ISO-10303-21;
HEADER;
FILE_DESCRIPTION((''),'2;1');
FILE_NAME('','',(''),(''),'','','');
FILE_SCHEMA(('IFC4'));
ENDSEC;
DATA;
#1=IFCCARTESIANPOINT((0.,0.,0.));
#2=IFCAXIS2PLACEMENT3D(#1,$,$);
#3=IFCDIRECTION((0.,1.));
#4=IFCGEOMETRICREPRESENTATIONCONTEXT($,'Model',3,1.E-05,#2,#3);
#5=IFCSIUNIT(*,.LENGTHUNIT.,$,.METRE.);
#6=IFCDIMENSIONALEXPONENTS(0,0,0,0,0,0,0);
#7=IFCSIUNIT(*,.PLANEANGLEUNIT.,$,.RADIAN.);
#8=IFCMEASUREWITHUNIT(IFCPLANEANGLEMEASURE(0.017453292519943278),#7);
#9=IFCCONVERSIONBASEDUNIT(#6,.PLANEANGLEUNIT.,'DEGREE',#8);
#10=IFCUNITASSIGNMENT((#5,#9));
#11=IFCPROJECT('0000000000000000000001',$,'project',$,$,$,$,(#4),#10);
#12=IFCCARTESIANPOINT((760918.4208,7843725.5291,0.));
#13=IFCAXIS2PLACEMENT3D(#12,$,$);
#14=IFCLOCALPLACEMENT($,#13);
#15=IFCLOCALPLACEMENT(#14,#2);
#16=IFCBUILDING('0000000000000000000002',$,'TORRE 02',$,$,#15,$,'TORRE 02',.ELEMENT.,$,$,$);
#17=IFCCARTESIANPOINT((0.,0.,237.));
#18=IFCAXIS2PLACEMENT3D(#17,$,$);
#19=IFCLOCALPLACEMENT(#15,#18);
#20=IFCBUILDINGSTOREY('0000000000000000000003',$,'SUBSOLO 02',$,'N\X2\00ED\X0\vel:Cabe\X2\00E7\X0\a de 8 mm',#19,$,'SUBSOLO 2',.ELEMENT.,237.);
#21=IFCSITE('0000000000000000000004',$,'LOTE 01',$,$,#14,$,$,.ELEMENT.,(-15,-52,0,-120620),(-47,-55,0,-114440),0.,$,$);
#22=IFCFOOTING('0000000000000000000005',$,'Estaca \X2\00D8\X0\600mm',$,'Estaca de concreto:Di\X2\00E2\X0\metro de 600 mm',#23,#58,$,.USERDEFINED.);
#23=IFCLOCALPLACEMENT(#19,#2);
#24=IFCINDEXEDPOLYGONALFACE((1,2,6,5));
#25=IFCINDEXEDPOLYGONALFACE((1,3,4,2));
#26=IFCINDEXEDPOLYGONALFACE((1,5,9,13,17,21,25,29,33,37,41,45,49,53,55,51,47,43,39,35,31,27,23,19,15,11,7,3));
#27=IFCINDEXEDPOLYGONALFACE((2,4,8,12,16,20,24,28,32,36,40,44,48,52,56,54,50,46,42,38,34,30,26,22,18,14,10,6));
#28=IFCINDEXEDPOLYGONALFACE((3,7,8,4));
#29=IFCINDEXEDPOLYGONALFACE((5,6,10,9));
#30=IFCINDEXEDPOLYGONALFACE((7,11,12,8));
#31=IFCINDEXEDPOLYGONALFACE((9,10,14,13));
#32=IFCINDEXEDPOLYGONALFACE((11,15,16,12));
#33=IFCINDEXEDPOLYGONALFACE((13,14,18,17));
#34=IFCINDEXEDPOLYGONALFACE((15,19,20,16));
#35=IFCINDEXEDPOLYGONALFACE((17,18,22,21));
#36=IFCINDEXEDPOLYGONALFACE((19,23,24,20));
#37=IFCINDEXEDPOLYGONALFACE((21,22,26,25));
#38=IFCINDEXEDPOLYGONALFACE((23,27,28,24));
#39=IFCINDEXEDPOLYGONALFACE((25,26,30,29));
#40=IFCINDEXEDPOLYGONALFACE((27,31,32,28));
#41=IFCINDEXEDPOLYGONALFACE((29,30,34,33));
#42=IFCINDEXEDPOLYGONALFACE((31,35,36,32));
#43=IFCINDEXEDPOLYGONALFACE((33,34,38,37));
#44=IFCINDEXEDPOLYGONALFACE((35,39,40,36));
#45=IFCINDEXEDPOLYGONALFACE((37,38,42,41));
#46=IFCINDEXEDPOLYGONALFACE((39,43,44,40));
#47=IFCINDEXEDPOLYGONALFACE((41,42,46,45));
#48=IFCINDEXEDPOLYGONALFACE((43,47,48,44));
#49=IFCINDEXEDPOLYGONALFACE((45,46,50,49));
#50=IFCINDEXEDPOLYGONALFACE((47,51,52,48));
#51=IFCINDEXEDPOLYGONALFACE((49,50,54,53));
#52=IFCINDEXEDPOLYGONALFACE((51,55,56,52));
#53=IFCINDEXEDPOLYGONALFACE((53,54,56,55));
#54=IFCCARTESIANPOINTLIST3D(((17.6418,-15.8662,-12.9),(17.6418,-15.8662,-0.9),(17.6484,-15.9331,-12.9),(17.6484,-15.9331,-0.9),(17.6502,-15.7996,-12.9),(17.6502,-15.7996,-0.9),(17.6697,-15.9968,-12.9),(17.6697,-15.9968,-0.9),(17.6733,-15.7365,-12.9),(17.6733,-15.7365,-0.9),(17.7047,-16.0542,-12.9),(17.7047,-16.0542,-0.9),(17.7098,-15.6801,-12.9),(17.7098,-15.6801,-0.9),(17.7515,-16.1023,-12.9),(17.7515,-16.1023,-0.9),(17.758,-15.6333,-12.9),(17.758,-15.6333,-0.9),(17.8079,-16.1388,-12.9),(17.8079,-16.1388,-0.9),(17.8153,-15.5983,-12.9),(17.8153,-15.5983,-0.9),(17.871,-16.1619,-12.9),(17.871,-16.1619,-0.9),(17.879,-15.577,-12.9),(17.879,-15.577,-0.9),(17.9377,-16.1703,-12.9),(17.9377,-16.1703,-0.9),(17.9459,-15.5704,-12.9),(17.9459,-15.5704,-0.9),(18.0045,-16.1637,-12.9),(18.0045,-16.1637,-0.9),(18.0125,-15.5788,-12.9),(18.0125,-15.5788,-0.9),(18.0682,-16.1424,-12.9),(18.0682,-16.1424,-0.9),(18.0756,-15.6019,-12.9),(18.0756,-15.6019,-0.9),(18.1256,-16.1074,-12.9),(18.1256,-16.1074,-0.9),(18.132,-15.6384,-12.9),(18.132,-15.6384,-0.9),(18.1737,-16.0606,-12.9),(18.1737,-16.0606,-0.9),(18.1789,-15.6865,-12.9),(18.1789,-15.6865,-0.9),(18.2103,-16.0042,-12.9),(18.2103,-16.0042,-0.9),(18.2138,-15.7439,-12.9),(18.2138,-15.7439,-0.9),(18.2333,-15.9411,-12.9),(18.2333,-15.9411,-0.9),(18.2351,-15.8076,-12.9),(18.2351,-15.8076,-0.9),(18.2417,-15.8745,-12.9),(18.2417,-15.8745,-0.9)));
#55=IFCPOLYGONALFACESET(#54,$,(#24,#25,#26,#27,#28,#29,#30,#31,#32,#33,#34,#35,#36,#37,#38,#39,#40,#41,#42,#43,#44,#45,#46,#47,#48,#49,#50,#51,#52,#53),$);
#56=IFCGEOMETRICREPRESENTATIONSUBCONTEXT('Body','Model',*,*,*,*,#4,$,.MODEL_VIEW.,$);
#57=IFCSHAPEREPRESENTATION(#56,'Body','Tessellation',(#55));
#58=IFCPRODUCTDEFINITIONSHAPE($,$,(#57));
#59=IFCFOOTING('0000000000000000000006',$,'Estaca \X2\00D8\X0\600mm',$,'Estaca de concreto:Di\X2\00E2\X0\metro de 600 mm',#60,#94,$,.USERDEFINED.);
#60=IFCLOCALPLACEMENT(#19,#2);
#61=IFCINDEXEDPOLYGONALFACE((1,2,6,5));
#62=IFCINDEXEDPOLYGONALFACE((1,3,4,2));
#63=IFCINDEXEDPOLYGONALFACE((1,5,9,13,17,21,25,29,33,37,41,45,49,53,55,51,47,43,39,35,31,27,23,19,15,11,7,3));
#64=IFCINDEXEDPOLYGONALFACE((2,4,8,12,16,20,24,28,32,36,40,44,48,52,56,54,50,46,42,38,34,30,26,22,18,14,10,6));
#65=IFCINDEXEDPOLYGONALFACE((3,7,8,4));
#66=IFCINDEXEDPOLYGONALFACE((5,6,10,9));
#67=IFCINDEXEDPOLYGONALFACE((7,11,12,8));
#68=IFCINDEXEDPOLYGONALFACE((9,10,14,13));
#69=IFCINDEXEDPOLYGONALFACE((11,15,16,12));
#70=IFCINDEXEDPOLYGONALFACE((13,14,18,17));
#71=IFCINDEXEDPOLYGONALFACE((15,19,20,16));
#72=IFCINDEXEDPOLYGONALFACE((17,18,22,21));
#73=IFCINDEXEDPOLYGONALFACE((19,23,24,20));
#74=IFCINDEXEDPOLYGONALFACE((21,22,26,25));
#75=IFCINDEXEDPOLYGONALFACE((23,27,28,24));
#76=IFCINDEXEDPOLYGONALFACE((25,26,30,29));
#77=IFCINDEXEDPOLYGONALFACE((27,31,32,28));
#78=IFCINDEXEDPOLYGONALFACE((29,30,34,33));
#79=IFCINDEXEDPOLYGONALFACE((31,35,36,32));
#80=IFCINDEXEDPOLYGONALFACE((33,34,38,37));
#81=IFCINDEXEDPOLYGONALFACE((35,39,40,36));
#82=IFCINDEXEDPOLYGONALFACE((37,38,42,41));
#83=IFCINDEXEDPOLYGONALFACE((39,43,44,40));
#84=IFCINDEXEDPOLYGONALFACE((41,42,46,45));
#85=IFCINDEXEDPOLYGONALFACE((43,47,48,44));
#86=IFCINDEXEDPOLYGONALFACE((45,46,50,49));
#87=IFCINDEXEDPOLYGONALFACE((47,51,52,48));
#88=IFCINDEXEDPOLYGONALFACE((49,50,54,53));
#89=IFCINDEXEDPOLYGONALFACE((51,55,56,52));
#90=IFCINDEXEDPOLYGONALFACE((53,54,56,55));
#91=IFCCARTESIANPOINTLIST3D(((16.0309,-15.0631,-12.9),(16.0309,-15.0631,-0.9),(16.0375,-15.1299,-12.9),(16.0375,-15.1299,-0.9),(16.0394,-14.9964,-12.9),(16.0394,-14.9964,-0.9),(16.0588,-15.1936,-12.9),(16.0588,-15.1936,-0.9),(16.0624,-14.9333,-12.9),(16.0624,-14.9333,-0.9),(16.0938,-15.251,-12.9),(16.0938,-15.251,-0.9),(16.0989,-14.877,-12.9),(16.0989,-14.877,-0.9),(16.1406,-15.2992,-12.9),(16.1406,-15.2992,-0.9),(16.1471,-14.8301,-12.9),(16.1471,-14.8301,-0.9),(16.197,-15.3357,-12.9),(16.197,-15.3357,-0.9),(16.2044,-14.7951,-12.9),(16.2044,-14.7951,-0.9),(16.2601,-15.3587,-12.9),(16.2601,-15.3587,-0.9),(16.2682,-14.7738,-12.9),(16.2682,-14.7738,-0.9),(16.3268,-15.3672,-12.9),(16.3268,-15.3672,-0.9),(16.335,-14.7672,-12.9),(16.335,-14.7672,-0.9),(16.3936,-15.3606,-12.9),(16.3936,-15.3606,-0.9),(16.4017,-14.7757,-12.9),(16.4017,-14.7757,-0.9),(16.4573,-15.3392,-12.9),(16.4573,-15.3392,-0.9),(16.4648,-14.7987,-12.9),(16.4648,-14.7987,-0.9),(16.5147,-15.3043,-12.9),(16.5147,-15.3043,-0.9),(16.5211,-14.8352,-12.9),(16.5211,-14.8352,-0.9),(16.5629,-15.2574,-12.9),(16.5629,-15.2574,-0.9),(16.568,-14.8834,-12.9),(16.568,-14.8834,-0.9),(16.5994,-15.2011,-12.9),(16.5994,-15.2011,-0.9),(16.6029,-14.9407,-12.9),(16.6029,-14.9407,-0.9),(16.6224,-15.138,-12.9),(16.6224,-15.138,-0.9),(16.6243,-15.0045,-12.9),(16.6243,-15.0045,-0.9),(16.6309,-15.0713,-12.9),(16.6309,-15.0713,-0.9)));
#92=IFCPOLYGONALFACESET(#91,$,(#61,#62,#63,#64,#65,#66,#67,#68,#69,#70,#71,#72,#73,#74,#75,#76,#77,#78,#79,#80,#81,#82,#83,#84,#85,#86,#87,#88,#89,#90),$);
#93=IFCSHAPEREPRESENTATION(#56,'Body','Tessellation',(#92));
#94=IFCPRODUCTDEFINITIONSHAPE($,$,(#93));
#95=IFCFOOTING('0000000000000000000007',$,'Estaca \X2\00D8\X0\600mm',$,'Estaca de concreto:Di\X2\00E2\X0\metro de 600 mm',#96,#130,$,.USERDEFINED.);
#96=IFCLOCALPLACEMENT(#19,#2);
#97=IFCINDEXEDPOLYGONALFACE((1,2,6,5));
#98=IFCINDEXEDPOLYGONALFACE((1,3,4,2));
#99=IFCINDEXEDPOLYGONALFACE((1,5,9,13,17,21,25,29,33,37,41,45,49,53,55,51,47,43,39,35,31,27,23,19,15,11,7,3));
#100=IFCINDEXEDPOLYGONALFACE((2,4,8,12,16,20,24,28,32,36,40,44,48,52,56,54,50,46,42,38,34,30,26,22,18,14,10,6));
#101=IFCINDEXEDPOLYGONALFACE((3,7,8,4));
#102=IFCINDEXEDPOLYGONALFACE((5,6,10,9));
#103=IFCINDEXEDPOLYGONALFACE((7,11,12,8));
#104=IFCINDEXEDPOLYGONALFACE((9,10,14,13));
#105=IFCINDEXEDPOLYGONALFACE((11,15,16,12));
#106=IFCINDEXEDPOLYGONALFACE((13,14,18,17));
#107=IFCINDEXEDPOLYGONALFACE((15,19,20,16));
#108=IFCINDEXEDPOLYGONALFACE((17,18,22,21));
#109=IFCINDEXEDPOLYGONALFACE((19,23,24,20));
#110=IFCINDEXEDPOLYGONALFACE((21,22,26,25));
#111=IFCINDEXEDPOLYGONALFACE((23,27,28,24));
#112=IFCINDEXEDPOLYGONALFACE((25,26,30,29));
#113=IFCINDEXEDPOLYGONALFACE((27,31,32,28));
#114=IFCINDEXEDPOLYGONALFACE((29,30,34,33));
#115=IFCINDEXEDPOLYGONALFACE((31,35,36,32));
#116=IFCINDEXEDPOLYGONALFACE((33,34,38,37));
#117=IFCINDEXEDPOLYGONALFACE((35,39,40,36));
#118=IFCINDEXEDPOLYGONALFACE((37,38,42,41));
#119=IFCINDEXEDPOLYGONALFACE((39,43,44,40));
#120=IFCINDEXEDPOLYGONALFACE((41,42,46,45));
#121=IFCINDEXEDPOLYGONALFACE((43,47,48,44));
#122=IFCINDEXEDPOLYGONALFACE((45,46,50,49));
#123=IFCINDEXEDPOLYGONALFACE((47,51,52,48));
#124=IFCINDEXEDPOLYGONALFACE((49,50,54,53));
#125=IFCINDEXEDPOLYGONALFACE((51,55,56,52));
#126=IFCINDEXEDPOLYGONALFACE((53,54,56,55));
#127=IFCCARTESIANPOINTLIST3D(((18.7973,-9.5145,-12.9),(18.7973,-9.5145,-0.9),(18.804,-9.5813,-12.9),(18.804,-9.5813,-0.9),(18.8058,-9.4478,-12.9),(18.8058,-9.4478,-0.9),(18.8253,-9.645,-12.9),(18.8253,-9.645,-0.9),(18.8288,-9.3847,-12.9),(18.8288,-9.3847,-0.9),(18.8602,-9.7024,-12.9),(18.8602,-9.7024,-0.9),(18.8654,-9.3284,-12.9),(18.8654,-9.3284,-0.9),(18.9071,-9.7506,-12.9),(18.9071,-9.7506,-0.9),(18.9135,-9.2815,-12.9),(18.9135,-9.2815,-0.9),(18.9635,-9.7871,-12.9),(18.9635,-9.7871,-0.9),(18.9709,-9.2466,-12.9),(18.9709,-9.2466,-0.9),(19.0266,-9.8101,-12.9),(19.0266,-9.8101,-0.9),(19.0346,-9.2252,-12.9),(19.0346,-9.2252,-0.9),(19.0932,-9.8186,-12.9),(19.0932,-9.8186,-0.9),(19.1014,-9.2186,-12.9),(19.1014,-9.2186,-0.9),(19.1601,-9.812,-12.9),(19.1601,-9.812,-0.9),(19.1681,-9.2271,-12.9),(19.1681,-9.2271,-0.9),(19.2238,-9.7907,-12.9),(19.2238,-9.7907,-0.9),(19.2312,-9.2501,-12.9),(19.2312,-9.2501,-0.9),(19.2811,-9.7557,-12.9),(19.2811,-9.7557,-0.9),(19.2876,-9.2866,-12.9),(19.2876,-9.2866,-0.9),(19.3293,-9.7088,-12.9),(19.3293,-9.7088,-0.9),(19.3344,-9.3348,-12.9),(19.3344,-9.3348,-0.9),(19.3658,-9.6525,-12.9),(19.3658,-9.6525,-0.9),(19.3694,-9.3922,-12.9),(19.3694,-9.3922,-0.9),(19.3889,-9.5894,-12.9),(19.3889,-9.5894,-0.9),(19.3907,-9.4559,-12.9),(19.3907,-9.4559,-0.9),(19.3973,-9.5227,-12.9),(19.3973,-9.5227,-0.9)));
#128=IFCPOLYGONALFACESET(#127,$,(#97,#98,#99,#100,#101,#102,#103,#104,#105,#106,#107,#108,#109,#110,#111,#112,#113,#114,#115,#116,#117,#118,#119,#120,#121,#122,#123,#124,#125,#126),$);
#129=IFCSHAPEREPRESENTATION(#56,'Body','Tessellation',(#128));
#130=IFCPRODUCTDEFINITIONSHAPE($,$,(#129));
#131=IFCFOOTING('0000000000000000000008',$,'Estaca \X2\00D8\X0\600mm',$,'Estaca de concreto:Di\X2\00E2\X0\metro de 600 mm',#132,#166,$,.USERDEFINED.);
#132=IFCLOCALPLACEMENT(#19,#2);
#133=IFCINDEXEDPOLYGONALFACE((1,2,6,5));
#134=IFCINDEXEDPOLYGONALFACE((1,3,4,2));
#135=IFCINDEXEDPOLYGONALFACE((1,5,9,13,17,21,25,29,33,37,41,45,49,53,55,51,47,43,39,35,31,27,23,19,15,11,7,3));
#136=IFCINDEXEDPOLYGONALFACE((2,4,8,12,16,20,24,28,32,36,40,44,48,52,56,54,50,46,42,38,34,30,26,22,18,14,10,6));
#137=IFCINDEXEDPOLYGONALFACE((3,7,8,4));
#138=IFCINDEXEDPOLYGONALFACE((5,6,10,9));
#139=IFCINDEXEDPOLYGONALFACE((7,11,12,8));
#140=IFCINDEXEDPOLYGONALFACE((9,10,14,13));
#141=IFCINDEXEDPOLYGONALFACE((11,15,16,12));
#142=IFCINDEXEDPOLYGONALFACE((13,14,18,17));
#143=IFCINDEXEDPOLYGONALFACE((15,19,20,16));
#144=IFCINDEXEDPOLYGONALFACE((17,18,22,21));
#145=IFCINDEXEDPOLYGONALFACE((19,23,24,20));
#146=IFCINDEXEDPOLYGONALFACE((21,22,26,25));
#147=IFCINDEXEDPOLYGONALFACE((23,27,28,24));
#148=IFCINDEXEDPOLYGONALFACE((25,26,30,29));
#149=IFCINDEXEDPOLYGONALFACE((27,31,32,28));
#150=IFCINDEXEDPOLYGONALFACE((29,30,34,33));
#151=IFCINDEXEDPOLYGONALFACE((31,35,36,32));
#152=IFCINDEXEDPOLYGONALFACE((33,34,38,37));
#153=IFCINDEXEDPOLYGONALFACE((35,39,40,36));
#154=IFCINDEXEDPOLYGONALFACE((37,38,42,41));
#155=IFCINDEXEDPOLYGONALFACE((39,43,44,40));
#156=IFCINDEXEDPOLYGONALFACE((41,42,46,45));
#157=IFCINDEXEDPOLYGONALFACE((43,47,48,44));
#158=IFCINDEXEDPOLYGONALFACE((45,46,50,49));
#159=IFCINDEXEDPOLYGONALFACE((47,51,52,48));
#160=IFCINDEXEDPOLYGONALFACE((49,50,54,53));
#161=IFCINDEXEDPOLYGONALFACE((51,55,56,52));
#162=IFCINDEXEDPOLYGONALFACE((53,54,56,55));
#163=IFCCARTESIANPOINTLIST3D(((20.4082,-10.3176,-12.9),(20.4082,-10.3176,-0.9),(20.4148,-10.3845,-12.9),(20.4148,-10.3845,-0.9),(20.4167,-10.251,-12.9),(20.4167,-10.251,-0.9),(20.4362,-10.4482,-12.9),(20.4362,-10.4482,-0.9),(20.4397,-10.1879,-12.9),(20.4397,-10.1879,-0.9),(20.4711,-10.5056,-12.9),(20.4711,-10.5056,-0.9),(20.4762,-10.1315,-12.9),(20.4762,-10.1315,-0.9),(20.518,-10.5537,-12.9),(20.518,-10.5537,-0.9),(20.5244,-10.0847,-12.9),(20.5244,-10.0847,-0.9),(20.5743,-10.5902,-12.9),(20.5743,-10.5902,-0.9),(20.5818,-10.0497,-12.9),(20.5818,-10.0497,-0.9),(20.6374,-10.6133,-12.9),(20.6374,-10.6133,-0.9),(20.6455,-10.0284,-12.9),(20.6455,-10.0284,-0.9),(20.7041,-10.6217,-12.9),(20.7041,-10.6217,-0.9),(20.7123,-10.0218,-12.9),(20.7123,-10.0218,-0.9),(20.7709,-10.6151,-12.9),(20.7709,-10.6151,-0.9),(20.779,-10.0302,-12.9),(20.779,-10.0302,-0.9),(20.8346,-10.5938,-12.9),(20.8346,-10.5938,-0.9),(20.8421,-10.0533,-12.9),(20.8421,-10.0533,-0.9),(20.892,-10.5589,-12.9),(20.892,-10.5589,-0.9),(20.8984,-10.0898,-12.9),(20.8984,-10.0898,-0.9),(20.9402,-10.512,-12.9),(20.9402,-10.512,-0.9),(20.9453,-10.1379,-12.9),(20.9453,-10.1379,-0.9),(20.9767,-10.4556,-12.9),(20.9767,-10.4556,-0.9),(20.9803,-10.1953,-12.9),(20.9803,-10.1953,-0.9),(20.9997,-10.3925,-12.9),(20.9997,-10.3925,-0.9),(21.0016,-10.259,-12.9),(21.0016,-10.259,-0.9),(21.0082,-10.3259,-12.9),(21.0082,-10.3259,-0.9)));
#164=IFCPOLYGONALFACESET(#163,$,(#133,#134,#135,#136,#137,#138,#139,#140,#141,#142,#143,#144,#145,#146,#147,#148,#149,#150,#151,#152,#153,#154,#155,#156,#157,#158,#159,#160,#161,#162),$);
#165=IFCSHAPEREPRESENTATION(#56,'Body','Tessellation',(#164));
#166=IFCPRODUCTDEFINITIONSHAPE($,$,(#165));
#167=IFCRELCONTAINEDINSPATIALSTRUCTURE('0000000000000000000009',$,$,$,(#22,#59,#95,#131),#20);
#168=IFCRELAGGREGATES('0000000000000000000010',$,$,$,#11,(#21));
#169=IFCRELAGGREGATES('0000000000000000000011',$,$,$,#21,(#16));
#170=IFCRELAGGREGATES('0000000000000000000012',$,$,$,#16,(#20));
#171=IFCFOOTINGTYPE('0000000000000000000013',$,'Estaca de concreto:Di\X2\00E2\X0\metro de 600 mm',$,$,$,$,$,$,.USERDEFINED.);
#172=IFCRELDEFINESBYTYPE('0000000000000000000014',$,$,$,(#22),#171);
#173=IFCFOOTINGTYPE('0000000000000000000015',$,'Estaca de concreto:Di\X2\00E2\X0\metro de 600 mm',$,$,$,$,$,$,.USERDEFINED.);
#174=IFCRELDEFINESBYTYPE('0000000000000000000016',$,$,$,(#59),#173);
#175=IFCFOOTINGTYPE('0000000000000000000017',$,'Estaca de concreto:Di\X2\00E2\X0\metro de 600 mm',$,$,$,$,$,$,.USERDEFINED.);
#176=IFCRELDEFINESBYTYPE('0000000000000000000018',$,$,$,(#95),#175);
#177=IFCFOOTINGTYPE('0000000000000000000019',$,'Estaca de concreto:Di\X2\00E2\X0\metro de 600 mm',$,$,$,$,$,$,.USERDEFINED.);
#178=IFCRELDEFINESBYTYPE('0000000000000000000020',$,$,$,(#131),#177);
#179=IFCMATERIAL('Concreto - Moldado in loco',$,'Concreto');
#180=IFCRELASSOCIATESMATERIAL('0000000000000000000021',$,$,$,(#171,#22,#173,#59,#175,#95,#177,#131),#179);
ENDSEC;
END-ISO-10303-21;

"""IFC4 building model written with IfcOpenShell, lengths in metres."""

from ifc_helpers import new_model, entity, si_unit, converted_unit, direction, frame, origin, place, context, subcontext, project, spatial, arc, indexed_curve, outline, extrude, source, transform, mapped, material, type_object, type_shapes, element, save


model = new_model("IFC4")

# Units and contexts
model_context = context("Model", 3, precision=1e-05, world=origin(), true_north=direction((0.0, 1.0)))
body_context = subcontext(model_context, "Body", "Model", "MODEL_VIEW")
ifc_project = project(units=[si_unit("LENGTHUNIT", "METRE"), converted_unit("PLANEANGLEUNIT", "DEGREE", entity("IfcPlaneAngleMeasure", 0.017453292519943278), si_unit("PLANEANGLEUNIT", "RADIAN"), dimensions=[0, 0, 0, 0, 0, 0, 0])], contexts=[model_context])

# Site, building, storey
site_placement = place(None, frame((760918.4208, 7843725.5291, 0.0)))
site = spatial("IfcSite", under=ifc_project, at=site_placement, Name="LOTE 01", CompositionType="ELEMENT", RefLatitude=(-15, -52, 0, -120620), RefLongitude=(-47, -55, 0, -114440), RefElevation=0.0)
building_placement = place(site_placement, origin())
building = spatial("IfcBuilding", under=site, at=building_placement, Name="TORRE 02", LongName="TORRE 02", CompositionType="ELEMENT")
storey_placement = place(building_placement, frame((0.0, 0.0, 237.0)))
storey = spatial("IfcBuildingStorey", under=building, at=storey_placement, Name="SUBSOLO 02", ObjectType="Nível:Cabeça de 8 mm", LongName="SUBSOLO 2", CompositionType="ELEMENT", Elevation=237.0)

# Footings
ifc_material = material(Name="Concreto - Moldado in loco", Category="Concreto")
placement = place(building_placement, frame((0.0, 0.0, 237.0)))
footing_type_1 = type_object("IfcFootingType", Name="Estaca de concreto:Diâmetro de 600 mm", PredefinedType="USERDEFINED", material=ifc_material)
shared_shape_1 = source(origin(), body_context, "Body", "SweptSolid", [
    extrude(outline(indexed_curve([(-0.3, 0.0), (0.0, -0.3), (0.3, 0.0), (0.0, 0.3)], segments=[arc(1, 2, 3), arc(3, 4, 1)], self_intersect=False)), frame((17.9418, -15.8704, -12.0), z_axis=(0.0, 0.0, 1.0), x_axis=(0.894934, -0.446198, 0.0)), (0.0, 0.0, 1.0), 12.0),
])
type_shapes(footing_type_1, [shared_shape_1])
footing_1_placement = place(placement, frame((0.0, 0.0, -0.9)))
element("IfcFooting", 1, at=footing_1_placement, inside=storey, type_object=footing_type_1, material=ifc_material, Name="Estaca Ø600mm", ObjectType="Estaca de concreto:Diâmetro de 600 mm", PredefinedType="USERDEFINED", context=body_context, shape_type="MappedRepresentation", body=[
    mapped(shared_shape_1, transform((0.0, 0.0, 0.0), scale=1.0)),
])
footing_type_2 = type_object("IfcFootingType", Name="Estaca de concreto:Diâmetro de 600 mm", PredefinedType="USERDEFINED", material=ifc_material)
shared_shape_2 = source(origin(), body_context, "Body", "SweptSolid", [
    extrude(outline(indexed_curve([(-0.3, 0.0), (0.0, -0.3), (0.3, 0.0), (0.0, 0.3)], segments=[arc(1, 2, 3), arc(3, 4, 1)], self_intersect=False)), frame((16.3309, -15.0672, -12.0), z_axis=(0.0, 0.0, 1.0), x_axis=(0.894934, -0.446198, 0.0)), (0.0, 0.0, 1.0), 12.0),
])
type_shapes(footing_type_2, [shared_shape_2])
footing_2_placement = place(placement, frame((0.0, 0.0, -0.9)))
element("IfcFooting", 2, at=footing_2_placement, inside=storey, type_object=footing_type_2, material=ifc_material, Name="Estaca Ø600mm", ObjectType="Estaca de concreto:Diâmetro de 600 mm", PredefinedType="USERDEFINED", context=body_context, shape_type="MappedRepresentation", body=[
    mapped(shared_shape_2, transform((0.0, 0.0, 0.0), scale=1.0)),
])
footing_type_3 = type_object("IfcFootingType", Name="Estaca de concreto:Diâmetro de 600 mm", PredefinedType="USERDEFINED", material=ifc_material)
shared_shape_3 = source(origin(), body_context, "Body", "SweptSolid", [
    extrude(outline(indexed_curve([(-0.3, 0.0), (0.0, -0.3), (0.3, 0.0), (0.0, 0.3)], segments=[arc(1, 2, 3), arc(3, 4, 1)], self_intersect=False)), frame((19.0973, -9.5186, -12.0), z_axis=(0.0, 0.0, 1.0), x_axis=(0.894934, -0.446198, 0.0)), (0.0, 0.0, 1.0), 12.0),
])
type_shapes(footing_type_3, [shared_shape_3])
footing_3_placement = place(placement, frame((0.0, 0.0, -0.9)))
element("IfcFooting", 3, at=footing_3_placement, inside=storey, type_object=footing_type_3, material=ifc_material, Name="Estaca Ø600mm", ObjectType="Estaca de concreto:Diâmetro de 600 mm", PredefinedType="USERDEFINED", context=body_context, shape_type="MappedRepresentation", body=[
    mapped(shared_shape_3, transform((0.0, 0.0, 0.0), scale=1.0)),
])
footing_type_4 = type_object("IfcFootingType", Name="Estaca de concreto:Diâmetro de 600 mm", PredefinedType="USERDEFINED", material=ifc_material)
shared_shape_4 = source(origin(), body_context, "Body", "SweptSolid", [
    extrude(outline(indexed_curve([(-0.3, 0.0), (0.0, -0.3), (0.3, 0.0), (0.0, 0.3)], segments=[arc(1, 2, 3), arc(3, 4, 1)], self_intersect=False)), frame((20.7082, -10.3218, -12.0), z_axis=(0.0, 0.0, 1.0), x_axis=(0.894934, -0.446198, 0.0)), (0.0, 0.0, 1.0), 12.0),
])
type_shapes(footing_type_4, [shared_shape_4])
footing_4_placement = place(placement, frame((0.0, 0.0, -0.9)))
element("IfcFooting", 4, at=footing_4_placement, inside=storey, type_object=footing_type_4, material=ifc_material, Name="Estaca Ø600mm", ObjectType="Estaca de concreto:Diâmetro de 600 mm", PredefinedType="USERDEFINED", context=body_context, shape_type="MappedRepresentation", body=[
    mapped(shared_shape_4, transform((0.0, 0.0, 0.0), scale=1.0)),
])

save(model, "model.ifc")
